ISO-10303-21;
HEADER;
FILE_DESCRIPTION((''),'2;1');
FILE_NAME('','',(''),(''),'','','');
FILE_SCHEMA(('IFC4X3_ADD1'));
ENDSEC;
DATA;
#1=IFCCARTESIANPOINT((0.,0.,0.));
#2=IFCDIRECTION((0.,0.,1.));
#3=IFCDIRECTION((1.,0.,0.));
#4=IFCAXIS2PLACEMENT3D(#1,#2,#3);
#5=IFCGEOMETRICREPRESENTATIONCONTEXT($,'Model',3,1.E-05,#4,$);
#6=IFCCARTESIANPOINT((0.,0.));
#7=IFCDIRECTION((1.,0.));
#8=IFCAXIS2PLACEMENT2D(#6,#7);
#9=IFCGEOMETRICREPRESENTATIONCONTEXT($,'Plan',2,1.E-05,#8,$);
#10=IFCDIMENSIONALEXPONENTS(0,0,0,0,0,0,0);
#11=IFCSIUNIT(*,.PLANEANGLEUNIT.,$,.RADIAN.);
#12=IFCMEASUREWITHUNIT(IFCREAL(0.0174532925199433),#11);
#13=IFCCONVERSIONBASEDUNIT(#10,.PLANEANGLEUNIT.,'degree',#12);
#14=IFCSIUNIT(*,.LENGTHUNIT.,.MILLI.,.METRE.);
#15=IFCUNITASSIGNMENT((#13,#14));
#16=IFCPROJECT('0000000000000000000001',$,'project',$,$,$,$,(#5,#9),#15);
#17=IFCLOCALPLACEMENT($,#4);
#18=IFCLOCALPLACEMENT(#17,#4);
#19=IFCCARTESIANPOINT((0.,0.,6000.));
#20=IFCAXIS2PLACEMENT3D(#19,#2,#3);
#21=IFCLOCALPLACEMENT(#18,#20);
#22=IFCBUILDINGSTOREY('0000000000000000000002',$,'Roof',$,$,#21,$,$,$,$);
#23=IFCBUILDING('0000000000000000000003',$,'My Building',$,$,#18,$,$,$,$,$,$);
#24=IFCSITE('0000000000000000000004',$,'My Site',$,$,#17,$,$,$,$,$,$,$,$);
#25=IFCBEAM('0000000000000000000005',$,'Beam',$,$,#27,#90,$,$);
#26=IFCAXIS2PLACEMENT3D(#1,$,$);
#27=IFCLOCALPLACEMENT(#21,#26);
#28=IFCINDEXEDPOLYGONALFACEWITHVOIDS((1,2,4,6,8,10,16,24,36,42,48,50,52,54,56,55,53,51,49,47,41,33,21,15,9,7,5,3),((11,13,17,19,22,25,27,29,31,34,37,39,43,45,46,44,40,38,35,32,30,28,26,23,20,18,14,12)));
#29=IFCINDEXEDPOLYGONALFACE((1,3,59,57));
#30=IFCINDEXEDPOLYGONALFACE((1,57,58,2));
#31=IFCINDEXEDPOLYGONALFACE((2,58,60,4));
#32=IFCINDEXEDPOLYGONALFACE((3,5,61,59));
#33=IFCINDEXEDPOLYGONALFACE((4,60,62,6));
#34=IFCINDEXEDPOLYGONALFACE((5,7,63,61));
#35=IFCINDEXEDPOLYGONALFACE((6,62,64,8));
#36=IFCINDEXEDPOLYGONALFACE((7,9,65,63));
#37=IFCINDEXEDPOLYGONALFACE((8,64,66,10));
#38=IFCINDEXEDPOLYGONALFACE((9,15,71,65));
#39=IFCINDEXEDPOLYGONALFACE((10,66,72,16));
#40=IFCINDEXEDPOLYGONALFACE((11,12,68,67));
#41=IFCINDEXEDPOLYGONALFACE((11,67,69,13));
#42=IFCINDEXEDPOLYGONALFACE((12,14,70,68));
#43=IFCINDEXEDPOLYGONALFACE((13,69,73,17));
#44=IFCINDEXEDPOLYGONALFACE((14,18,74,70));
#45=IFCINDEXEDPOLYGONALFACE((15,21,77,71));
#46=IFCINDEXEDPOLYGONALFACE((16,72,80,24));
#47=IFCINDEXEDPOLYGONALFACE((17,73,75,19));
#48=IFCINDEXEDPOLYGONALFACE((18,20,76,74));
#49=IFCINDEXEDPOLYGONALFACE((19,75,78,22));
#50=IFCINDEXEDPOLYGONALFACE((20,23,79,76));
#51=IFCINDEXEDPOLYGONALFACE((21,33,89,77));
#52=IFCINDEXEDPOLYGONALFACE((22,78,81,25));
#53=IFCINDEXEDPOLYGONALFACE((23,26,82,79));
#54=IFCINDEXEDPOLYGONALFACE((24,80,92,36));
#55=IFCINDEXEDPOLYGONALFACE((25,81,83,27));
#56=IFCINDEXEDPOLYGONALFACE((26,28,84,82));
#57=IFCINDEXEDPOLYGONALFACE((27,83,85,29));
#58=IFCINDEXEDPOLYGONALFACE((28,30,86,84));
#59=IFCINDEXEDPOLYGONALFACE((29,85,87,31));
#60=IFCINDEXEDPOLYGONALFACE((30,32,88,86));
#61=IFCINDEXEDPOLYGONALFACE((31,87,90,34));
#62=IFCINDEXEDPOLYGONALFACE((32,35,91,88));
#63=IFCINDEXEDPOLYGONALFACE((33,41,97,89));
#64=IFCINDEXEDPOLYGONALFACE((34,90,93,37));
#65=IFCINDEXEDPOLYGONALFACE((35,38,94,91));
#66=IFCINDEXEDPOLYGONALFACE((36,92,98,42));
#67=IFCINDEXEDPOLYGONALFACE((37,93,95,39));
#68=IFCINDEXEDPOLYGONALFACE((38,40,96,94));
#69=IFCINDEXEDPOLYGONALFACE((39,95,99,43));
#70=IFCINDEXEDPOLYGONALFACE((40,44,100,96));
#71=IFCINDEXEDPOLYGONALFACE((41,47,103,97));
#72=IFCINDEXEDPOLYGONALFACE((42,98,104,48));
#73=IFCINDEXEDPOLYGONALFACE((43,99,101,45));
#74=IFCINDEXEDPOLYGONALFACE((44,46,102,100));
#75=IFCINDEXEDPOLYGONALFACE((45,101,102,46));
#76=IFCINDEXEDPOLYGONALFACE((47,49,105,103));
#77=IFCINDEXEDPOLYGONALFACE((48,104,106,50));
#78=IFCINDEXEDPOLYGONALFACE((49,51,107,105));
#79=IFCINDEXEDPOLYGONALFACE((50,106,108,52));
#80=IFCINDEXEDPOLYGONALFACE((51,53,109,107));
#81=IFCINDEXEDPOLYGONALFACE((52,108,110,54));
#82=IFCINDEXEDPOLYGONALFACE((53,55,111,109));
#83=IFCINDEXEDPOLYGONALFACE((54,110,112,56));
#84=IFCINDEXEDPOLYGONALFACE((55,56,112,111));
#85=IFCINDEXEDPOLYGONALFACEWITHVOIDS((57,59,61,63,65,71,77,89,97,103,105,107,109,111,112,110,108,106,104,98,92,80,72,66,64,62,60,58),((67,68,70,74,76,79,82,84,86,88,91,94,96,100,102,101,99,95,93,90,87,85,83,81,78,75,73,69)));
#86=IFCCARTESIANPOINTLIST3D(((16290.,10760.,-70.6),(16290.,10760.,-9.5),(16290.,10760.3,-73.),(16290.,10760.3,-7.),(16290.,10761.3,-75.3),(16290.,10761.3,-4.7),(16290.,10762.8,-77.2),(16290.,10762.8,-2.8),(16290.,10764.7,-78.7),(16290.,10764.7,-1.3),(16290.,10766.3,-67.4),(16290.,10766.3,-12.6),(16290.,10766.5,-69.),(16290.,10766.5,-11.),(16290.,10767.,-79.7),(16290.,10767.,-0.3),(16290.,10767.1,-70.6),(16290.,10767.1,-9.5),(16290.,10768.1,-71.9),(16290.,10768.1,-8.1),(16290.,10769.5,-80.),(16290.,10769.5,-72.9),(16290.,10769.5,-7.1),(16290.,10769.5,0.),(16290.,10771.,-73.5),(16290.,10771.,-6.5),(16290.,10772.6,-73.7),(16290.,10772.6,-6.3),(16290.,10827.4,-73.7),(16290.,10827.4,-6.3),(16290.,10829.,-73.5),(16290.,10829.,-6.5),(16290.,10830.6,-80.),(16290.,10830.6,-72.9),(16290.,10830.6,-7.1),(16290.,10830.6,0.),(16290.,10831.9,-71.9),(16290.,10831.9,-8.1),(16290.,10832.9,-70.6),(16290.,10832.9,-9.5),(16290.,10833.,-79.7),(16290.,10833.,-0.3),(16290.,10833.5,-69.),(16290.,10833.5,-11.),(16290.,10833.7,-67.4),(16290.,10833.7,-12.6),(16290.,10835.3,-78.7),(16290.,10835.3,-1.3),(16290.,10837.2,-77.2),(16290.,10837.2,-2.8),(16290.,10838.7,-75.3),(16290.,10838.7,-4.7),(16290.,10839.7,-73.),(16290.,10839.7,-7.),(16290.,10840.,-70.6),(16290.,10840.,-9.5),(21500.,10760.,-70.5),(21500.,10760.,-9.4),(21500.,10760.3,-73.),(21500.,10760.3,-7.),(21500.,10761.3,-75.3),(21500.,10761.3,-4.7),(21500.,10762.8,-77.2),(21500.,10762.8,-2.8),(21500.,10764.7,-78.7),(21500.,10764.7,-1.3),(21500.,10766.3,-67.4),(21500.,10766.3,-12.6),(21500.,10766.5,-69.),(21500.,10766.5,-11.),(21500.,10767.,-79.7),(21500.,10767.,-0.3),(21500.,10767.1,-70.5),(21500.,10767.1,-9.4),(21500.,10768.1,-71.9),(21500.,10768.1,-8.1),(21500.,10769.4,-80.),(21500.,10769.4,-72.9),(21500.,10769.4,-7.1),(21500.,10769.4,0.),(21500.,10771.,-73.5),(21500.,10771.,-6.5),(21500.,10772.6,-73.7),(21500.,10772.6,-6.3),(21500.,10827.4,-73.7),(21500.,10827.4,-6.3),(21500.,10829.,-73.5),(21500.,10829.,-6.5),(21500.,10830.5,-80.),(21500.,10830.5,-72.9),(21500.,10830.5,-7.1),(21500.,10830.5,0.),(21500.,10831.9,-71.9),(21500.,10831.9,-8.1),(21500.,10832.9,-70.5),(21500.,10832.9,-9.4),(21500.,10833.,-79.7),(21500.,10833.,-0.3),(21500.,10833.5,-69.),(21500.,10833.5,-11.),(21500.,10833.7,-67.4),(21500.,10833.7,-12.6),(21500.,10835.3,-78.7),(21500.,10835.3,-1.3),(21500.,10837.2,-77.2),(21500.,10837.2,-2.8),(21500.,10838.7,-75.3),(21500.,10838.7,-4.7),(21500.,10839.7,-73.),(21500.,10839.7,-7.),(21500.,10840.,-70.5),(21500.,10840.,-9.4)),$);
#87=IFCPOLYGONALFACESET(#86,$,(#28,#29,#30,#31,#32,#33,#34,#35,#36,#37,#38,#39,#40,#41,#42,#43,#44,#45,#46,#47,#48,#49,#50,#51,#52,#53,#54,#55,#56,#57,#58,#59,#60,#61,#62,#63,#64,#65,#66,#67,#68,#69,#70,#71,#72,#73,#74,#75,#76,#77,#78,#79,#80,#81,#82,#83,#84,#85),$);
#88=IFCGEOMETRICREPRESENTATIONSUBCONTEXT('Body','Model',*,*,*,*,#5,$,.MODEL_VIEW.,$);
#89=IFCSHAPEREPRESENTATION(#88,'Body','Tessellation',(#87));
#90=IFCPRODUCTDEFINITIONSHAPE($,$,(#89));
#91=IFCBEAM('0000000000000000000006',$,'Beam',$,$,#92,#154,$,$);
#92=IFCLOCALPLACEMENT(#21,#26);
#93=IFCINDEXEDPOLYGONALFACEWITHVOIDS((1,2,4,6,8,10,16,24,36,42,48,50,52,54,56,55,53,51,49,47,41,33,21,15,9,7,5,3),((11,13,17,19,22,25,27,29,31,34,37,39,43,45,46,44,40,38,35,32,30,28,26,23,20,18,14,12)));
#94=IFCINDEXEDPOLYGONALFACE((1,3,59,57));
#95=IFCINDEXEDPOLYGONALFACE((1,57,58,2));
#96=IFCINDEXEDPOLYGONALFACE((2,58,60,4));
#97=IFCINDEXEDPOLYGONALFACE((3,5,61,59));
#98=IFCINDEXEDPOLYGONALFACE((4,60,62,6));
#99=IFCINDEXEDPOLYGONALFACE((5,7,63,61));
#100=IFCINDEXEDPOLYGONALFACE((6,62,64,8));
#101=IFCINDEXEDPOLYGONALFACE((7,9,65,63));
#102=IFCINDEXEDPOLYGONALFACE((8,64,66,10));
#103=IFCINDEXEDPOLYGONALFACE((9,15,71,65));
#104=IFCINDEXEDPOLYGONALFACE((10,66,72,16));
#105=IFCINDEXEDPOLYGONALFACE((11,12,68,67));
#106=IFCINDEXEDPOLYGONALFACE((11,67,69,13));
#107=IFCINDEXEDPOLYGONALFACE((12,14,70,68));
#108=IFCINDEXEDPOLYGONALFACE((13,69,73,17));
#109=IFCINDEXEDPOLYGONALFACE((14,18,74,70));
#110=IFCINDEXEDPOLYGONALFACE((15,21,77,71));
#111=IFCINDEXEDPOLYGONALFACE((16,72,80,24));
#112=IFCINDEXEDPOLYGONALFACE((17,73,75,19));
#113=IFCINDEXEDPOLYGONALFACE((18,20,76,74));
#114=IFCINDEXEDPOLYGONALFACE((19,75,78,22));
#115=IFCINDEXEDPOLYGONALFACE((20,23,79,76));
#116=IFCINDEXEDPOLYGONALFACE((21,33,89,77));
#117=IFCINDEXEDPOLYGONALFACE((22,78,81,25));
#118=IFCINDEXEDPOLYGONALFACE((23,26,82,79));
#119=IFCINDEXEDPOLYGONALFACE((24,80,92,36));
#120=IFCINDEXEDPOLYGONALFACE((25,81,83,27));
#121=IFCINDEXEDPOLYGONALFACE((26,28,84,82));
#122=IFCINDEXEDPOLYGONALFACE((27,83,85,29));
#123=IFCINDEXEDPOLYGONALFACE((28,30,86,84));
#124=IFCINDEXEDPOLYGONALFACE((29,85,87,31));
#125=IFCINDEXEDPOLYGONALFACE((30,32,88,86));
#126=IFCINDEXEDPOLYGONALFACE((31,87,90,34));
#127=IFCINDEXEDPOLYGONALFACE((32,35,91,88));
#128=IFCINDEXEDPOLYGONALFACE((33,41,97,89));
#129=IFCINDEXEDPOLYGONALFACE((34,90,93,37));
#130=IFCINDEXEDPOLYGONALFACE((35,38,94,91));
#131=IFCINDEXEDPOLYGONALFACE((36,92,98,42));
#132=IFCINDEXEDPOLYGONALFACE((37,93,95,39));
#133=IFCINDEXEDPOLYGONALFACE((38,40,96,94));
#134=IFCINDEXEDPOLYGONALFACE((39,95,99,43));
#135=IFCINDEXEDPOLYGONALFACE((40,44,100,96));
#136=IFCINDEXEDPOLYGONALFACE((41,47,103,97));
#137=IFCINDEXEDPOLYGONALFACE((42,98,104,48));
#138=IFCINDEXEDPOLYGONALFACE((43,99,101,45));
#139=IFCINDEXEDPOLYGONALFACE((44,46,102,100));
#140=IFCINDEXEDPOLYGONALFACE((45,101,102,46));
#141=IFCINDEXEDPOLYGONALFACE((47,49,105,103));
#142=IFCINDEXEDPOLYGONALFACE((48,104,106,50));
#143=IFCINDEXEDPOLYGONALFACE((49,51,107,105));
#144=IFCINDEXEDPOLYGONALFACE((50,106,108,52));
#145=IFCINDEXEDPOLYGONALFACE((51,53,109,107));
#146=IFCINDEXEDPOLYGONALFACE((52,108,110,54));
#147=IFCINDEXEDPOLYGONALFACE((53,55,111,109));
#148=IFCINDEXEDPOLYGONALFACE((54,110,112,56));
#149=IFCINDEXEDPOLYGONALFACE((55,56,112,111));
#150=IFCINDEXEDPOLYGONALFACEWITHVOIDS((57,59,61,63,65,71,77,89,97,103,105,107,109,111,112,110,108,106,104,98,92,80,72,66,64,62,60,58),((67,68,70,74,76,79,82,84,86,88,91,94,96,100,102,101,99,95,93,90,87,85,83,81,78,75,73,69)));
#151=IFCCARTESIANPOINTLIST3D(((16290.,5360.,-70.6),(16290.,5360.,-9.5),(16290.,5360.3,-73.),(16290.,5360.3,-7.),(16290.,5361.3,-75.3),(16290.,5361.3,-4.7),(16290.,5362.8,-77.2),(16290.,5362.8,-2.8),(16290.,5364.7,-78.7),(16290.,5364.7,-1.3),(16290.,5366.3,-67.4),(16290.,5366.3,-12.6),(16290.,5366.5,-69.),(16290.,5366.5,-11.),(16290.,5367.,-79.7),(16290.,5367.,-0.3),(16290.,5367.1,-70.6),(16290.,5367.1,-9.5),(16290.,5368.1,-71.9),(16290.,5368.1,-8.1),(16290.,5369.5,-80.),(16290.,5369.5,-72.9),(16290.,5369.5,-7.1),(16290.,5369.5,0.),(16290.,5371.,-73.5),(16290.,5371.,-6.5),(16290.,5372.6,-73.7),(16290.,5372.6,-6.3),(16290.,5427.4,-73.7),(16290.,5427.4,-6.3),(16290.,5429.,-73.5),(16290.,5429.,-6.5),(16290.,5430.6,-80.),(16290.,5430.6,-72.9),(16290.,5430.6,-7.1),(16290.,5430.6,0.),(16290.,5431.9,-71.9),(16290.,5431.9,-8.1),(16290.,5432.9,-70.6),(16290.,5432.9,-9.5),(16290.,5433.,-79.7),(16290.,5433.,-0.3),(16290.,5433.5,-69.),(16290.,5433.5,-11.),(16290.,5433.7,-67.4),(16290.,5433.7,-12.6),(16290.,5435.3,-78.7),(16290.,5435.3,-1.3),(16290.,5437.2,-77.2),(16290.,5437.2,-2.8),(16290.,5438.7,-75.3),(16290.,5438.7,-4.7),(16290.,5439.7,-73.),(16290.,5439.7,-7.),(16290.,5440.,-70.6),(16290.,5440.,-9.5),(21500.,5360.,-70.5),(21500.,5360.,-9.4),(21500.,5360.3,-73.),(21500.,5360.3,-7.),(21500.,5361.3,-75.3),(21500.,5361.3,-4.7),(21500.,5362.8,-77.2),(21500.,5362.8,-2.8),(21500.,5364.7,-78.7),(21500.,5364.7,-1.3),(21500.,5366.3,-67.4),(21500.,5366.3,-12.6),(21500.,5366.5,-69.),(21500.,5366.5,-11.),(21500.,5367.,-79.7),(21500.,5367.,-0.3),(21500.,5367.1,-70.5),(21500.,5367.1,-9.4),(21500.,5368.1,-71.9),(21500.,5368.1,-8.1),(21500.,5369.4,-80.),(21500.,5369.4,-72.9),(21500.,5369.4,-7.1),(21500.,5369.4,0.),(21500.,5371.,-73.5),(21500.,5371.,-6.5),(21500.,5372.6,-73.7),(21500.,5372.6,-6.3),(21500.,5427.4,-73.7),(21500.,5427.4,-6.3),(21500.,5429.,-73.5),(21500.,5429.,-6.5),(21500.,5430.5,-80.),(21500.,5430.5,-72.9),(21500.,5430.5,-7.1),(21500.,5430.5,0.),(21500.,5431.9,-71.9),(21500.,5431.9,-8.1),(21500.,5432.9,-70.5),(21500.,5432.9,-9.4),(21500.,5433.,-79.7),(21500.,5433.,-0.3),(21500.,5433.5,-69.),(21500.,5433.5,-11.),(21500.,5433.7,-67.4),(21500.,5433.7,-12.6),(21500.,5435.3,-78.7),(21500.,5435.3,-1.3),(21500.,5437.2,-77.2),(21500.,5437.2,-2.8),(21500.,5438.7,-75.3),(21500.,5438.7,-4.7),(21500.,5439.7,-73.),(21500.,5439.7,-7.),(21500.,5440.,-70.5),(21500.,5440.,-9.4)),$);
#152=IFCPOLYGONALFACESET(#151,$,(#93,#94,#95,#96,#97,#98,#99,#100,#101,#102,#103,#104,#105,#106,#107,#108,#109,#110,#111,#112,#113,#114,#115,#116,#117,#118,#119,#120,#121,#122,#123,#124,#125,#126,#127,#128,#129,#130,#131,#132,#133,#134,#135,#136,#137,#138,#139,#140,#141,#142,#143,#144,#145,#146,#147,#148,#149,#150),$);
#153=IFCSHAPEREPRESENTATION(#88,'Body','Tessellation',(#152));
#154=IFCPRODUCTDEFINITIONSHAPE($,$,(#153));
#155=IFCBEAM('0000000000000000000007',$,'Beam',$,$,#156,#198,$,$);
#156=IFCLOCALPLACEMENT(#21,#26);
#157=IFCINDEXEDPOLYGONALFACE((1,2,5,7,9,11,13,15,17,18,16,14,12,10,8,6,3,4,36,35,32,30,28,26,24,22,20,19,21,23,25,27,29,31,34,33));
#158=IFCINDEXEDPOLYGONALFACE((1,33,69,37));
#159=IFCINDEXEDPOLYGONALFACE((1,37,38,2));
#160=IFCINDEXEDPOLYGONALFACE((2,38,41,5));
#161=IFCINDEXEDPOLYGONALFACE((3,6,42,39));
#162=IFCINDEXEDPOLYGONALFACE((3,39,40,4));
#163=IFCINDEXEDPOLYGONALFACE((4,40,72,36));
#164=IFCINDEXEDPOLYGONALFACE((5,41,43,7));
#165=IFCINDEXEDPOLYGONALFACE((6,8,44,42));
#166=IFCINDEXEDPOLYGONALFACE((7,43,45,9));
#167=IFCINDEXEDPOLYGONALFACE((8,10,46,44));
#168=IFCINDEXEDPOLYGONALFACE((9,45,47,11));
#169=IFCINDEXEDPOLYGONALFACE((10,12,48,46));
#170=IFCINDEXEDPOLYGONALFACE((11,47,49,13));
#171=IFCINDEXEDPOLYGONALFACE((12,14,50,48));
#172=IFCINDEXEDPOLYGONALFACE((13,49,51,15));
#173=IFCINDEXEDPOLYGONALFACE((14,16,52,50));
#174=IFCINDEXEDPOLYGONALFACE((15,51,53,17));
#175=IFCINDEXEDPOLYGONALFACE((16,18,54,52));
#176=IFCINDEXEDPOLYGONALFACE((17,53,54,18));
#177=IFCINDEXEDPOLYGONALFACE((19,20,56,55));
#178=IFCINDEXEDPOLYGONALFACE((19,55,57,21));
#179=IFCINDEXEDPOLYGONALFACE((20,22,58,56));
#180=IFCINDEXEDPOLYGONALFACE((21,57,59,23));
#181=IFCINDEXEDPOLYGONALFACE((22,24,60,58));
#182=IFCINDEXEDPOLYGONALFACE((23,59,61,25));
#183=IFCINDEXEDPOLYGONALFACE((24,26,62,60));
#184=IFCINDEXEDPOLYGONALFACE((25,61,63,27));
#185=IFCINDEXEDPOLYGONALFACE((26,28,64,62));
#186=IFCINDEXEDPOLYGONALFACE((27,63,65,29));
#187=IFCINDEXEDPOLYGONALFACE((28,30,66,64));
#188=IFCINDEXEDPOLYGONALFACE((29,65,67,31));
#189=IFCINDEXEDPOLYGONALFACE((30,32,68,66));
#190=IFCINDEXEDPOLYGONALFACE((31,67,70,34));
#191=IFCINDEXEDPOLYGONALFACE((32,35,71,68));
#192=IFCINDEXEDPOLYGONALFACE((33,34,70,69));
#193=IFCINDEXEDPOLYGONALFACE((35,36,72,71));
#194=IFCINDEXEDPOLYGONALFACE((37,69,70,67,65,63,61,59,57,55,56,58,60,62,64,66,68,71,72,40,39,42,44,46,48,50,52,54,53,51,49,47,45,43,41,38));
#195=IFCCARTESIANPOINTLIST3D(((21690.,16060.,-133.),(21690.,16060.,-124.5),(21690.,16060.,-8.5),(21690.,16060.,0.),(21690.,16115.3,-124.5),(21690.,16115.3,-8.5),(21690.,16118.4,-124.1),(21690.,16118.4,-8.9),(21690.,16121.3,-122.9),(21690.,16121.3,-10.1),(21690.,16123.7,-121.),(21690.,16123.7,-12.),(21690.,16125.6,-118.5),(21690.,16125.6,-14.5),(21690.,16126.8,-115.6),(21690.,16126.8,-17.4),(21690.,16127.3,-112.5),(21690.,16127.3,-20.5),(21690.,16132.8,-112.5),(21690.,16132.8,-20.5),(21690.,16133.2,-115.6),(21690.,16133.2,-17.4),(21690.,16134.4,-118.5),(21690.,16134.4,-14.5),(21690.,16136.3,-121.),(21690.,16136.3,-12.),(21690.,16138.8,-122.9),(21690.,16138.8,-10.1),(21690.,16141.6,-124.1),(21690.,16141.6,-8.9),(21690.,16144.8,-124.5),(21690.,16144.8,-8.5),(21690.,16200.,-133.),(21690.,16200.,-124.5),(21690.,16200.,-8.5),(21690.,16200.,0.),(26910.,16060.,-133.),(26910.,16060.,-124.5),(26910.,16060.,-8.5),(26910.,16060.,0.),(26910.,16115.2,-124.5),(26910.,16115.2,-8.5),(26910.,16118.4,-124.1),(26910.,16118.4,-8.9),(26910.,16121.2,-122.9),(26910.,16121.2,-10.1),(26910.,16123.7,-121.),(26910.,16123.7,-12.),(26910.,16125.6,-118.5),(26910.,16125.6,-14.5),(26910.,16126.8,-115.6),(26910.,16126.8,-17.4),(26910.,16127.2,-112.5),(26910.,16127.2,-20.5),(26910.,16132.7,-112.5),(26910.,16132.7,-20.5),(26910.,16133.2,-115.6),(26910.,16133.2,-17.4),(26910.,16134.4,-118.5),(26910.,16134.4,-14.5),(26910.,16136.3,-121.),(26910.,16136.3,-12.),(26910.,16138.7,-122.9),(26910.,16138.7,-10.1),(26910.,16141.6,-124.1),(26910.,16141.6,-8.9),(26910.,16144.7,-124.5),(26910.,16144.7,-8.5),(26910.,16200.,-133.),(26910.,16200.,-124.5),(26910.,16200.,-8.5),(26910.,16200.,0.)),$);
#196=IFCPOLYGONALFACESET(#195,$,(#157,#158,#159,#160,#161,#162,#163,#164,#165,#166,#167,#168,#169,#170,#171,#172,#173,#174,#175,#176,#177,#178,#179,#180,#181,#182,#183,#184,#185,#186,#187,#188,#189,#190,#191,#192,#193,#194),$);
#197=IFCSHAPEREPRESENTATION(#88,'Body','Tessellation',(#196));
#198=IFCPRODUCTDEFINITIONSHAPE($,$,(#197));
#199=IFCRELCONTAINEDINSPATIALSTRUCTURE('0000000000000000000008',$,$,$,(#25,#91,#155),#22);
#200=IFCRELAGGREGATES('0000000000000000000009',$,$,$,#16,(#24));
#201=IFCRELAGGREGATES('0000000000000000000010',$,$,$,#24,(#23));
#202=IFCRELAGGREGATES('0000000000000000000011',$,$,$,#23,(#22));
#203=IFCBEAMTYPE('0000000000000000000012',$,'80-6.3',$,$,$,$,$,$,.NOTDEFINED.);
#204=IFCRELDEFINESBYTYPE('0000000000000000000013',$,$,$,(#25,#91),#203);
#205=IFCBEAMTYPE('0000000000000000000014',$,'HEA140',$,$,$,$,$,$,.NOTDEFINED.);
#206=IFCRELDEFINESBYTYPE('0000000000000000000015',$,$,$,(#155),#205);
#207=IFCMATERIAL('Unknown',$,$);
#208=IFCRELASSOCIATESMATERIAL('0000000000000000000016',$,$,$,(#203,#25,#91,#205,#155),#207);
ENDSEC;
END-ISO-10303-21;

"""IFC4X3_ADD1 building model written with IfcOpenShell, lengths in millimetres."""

from ifc_helpers import new_model, entity, si_unit, converted_unit, frame, origin_with_axes, origin_2d_with_axis, place, context, subcontext, project, spatial, hollow_rectangle, i_section, extrude, material, material_profile, profile_set, profile_usage, type_object, element, save


model = new_model("IFC4X3_ADD1")

# Units and contexts
model_context = context("Model", 3, precision=1e-05, world=origin_with_axes())
plan_context = context("Plan", 2, precision=1e-05, world=origin_2d_with_axis())
body_context = subcontext(model_context, "Body", "Model", "MODEL_VIEW")
ifc_project = project(units=[converted_unit("PLANEANGLEUNIT", "degree", entity("IfcReal", 0.0174532925199433), si_unit("PLANEANGLEUNIT", "RADIAN"), dimensions=[0, 0, 0, 0, 0, 0, 0]), si_unit("LENGTHUNIT", "METRE", prefix="MILLI")], contexts=[model_context, plan_context])

# Site, building, storey
site_placement = place(None, origin_with_axes())
site = spatial("IfcSite", under=ifc_project, at=site_placement, Name="My Site")
building_placement = place(site_placement, origin_with_axes())
building = spatial("IfcBuilding", under=site, at=building_placement, Name="My Building")
storey_placement = place(building_placement, frame((0.0, 0.0, 6000.0), z_axis=(0.0, 0.0, 1.0), x_axis=(1.0, 0.0, 0.0)))
storey = spatial("IfcBuildingStorey", under=building, at=storey_placement, Name="Roof")

# Beams
ifc_material = material(Name="Unknown")
ifc_material_profile_1 = material_profile(ifc_material, hollow_rectangle(XDim=80.0, YDim=80.0, WallThickness=6.3, InnerFilletRadius=6.3, OuterFilletRadius=9.4))
ifc_profile_set_1 = profile_set([ifc_material_profile_1])
beam_type_1 = type_object("IfcBeamType", Name="80-6.3", PredefinedType="NOTDEFINED", material=ifc_profile_set_1)
ifc_profile_usage_1 = profile_usage(ifc_profile_set_1, cardinal=8)
beam_1_placement = place(storey_placement, frame((16290.0, 10800.0, 0.0), z_axis=(1.0, 0.0, 0.0), x_axis=(0.0, 1.0, 0.0)))
element("IfcBeam", 1, at=beam_1_placement, inside=storey, type_object=beam_type_1, material=ifc_profile_usage_1, Name="Beam", context=body_context, shape_type="SweptSolid", body=[
    extrude(hollow_rectangle(XDim=80.0, YDim=80.0, WallThickness=6.3, InnerFilletRadius=6.3, OuterFilletRadius=9.4), frame((0.0, -40.0, 0.0), z_axis=(0.0, 0.0, 1.0), x_axis=(1.0, 0.0, 0.0)), (0.0, 0.0, 1.0), 5210.0),
])
ifc_profile_usage_2 = profile_usage(ifc_profile_set_1, cardinal=8)
beam_2_placement = place(storey_placement, frame((16290.0, 5400.0, 0.0), z_axis=(1.0, 0.0, 0.0), x_axis=(0.0, 1.0, 0.0)))
element("IfcBeam", 2, at=beam_2_placement, inside=storey, type_object=beam_type_1, material=ifc_profile_usage_2, Name="Beam", context=body_context, shape_type="SweptSolid", body=[
    extrude(hollow_rectangle(XDim=80.0, YDim=80.0, WallThickness=6.3, InnerFilletRadius=6.3, OuterFilletRadius=9.4), frame((0.0, -40.0, 0.0), z_axis=(0.0, 0.0, 1.0), x_axis=(1.0, 0.0, 0.0)), (0.0, 0.0, 1.0), 5210.0),
])
ifc_material_profile_2 = material_profile(ifc_material, i_section(OverallWidth=140.0, OverallDepth=133.0, WebThickness=5.5, FlangeThickness=8.5, FilletRadius=12.0))
ifc_profile_set_2 = profile_set([ifc_material_profile_2])
ifc_profile_usage_3 = profile_usage(ifc_profile_set_2, cardinal=7)
beam_type_2 = type_object("IfcBeamType", Name="HEA140", PredefinedType="NOTDEFINED", material=ifc_profile_set_2)
beam_3_placement = place(storey_placement, frame((21690.0, 16200.0, 0.0), z_axis=(1.0, 0.0, 0.0), x_axis=(0.0, 1.0, 0.0)))
element("IfcBeam", 3, at=beam_3_placement, inside=storey, type_object=beam_type_2, material=ifc_profile_usage_3, Name="Beam", context=body_context, shape_type="SweptSolid", body=[
    extrude(i_section(OverallWidth=140.0, OverallDepth=133.0, WebThickness=5.5, FlangeThickness=8.5, FilletRadius=12.0), frame((-70.0, -66.5, 0.0), z_axis=(0.0, 0.0, 1.0), x_axis=(1.0, 0.0, 0.0)), (0.0, 0.0, 1.0), 5220.0),
])

save(model, "model.ifc")
